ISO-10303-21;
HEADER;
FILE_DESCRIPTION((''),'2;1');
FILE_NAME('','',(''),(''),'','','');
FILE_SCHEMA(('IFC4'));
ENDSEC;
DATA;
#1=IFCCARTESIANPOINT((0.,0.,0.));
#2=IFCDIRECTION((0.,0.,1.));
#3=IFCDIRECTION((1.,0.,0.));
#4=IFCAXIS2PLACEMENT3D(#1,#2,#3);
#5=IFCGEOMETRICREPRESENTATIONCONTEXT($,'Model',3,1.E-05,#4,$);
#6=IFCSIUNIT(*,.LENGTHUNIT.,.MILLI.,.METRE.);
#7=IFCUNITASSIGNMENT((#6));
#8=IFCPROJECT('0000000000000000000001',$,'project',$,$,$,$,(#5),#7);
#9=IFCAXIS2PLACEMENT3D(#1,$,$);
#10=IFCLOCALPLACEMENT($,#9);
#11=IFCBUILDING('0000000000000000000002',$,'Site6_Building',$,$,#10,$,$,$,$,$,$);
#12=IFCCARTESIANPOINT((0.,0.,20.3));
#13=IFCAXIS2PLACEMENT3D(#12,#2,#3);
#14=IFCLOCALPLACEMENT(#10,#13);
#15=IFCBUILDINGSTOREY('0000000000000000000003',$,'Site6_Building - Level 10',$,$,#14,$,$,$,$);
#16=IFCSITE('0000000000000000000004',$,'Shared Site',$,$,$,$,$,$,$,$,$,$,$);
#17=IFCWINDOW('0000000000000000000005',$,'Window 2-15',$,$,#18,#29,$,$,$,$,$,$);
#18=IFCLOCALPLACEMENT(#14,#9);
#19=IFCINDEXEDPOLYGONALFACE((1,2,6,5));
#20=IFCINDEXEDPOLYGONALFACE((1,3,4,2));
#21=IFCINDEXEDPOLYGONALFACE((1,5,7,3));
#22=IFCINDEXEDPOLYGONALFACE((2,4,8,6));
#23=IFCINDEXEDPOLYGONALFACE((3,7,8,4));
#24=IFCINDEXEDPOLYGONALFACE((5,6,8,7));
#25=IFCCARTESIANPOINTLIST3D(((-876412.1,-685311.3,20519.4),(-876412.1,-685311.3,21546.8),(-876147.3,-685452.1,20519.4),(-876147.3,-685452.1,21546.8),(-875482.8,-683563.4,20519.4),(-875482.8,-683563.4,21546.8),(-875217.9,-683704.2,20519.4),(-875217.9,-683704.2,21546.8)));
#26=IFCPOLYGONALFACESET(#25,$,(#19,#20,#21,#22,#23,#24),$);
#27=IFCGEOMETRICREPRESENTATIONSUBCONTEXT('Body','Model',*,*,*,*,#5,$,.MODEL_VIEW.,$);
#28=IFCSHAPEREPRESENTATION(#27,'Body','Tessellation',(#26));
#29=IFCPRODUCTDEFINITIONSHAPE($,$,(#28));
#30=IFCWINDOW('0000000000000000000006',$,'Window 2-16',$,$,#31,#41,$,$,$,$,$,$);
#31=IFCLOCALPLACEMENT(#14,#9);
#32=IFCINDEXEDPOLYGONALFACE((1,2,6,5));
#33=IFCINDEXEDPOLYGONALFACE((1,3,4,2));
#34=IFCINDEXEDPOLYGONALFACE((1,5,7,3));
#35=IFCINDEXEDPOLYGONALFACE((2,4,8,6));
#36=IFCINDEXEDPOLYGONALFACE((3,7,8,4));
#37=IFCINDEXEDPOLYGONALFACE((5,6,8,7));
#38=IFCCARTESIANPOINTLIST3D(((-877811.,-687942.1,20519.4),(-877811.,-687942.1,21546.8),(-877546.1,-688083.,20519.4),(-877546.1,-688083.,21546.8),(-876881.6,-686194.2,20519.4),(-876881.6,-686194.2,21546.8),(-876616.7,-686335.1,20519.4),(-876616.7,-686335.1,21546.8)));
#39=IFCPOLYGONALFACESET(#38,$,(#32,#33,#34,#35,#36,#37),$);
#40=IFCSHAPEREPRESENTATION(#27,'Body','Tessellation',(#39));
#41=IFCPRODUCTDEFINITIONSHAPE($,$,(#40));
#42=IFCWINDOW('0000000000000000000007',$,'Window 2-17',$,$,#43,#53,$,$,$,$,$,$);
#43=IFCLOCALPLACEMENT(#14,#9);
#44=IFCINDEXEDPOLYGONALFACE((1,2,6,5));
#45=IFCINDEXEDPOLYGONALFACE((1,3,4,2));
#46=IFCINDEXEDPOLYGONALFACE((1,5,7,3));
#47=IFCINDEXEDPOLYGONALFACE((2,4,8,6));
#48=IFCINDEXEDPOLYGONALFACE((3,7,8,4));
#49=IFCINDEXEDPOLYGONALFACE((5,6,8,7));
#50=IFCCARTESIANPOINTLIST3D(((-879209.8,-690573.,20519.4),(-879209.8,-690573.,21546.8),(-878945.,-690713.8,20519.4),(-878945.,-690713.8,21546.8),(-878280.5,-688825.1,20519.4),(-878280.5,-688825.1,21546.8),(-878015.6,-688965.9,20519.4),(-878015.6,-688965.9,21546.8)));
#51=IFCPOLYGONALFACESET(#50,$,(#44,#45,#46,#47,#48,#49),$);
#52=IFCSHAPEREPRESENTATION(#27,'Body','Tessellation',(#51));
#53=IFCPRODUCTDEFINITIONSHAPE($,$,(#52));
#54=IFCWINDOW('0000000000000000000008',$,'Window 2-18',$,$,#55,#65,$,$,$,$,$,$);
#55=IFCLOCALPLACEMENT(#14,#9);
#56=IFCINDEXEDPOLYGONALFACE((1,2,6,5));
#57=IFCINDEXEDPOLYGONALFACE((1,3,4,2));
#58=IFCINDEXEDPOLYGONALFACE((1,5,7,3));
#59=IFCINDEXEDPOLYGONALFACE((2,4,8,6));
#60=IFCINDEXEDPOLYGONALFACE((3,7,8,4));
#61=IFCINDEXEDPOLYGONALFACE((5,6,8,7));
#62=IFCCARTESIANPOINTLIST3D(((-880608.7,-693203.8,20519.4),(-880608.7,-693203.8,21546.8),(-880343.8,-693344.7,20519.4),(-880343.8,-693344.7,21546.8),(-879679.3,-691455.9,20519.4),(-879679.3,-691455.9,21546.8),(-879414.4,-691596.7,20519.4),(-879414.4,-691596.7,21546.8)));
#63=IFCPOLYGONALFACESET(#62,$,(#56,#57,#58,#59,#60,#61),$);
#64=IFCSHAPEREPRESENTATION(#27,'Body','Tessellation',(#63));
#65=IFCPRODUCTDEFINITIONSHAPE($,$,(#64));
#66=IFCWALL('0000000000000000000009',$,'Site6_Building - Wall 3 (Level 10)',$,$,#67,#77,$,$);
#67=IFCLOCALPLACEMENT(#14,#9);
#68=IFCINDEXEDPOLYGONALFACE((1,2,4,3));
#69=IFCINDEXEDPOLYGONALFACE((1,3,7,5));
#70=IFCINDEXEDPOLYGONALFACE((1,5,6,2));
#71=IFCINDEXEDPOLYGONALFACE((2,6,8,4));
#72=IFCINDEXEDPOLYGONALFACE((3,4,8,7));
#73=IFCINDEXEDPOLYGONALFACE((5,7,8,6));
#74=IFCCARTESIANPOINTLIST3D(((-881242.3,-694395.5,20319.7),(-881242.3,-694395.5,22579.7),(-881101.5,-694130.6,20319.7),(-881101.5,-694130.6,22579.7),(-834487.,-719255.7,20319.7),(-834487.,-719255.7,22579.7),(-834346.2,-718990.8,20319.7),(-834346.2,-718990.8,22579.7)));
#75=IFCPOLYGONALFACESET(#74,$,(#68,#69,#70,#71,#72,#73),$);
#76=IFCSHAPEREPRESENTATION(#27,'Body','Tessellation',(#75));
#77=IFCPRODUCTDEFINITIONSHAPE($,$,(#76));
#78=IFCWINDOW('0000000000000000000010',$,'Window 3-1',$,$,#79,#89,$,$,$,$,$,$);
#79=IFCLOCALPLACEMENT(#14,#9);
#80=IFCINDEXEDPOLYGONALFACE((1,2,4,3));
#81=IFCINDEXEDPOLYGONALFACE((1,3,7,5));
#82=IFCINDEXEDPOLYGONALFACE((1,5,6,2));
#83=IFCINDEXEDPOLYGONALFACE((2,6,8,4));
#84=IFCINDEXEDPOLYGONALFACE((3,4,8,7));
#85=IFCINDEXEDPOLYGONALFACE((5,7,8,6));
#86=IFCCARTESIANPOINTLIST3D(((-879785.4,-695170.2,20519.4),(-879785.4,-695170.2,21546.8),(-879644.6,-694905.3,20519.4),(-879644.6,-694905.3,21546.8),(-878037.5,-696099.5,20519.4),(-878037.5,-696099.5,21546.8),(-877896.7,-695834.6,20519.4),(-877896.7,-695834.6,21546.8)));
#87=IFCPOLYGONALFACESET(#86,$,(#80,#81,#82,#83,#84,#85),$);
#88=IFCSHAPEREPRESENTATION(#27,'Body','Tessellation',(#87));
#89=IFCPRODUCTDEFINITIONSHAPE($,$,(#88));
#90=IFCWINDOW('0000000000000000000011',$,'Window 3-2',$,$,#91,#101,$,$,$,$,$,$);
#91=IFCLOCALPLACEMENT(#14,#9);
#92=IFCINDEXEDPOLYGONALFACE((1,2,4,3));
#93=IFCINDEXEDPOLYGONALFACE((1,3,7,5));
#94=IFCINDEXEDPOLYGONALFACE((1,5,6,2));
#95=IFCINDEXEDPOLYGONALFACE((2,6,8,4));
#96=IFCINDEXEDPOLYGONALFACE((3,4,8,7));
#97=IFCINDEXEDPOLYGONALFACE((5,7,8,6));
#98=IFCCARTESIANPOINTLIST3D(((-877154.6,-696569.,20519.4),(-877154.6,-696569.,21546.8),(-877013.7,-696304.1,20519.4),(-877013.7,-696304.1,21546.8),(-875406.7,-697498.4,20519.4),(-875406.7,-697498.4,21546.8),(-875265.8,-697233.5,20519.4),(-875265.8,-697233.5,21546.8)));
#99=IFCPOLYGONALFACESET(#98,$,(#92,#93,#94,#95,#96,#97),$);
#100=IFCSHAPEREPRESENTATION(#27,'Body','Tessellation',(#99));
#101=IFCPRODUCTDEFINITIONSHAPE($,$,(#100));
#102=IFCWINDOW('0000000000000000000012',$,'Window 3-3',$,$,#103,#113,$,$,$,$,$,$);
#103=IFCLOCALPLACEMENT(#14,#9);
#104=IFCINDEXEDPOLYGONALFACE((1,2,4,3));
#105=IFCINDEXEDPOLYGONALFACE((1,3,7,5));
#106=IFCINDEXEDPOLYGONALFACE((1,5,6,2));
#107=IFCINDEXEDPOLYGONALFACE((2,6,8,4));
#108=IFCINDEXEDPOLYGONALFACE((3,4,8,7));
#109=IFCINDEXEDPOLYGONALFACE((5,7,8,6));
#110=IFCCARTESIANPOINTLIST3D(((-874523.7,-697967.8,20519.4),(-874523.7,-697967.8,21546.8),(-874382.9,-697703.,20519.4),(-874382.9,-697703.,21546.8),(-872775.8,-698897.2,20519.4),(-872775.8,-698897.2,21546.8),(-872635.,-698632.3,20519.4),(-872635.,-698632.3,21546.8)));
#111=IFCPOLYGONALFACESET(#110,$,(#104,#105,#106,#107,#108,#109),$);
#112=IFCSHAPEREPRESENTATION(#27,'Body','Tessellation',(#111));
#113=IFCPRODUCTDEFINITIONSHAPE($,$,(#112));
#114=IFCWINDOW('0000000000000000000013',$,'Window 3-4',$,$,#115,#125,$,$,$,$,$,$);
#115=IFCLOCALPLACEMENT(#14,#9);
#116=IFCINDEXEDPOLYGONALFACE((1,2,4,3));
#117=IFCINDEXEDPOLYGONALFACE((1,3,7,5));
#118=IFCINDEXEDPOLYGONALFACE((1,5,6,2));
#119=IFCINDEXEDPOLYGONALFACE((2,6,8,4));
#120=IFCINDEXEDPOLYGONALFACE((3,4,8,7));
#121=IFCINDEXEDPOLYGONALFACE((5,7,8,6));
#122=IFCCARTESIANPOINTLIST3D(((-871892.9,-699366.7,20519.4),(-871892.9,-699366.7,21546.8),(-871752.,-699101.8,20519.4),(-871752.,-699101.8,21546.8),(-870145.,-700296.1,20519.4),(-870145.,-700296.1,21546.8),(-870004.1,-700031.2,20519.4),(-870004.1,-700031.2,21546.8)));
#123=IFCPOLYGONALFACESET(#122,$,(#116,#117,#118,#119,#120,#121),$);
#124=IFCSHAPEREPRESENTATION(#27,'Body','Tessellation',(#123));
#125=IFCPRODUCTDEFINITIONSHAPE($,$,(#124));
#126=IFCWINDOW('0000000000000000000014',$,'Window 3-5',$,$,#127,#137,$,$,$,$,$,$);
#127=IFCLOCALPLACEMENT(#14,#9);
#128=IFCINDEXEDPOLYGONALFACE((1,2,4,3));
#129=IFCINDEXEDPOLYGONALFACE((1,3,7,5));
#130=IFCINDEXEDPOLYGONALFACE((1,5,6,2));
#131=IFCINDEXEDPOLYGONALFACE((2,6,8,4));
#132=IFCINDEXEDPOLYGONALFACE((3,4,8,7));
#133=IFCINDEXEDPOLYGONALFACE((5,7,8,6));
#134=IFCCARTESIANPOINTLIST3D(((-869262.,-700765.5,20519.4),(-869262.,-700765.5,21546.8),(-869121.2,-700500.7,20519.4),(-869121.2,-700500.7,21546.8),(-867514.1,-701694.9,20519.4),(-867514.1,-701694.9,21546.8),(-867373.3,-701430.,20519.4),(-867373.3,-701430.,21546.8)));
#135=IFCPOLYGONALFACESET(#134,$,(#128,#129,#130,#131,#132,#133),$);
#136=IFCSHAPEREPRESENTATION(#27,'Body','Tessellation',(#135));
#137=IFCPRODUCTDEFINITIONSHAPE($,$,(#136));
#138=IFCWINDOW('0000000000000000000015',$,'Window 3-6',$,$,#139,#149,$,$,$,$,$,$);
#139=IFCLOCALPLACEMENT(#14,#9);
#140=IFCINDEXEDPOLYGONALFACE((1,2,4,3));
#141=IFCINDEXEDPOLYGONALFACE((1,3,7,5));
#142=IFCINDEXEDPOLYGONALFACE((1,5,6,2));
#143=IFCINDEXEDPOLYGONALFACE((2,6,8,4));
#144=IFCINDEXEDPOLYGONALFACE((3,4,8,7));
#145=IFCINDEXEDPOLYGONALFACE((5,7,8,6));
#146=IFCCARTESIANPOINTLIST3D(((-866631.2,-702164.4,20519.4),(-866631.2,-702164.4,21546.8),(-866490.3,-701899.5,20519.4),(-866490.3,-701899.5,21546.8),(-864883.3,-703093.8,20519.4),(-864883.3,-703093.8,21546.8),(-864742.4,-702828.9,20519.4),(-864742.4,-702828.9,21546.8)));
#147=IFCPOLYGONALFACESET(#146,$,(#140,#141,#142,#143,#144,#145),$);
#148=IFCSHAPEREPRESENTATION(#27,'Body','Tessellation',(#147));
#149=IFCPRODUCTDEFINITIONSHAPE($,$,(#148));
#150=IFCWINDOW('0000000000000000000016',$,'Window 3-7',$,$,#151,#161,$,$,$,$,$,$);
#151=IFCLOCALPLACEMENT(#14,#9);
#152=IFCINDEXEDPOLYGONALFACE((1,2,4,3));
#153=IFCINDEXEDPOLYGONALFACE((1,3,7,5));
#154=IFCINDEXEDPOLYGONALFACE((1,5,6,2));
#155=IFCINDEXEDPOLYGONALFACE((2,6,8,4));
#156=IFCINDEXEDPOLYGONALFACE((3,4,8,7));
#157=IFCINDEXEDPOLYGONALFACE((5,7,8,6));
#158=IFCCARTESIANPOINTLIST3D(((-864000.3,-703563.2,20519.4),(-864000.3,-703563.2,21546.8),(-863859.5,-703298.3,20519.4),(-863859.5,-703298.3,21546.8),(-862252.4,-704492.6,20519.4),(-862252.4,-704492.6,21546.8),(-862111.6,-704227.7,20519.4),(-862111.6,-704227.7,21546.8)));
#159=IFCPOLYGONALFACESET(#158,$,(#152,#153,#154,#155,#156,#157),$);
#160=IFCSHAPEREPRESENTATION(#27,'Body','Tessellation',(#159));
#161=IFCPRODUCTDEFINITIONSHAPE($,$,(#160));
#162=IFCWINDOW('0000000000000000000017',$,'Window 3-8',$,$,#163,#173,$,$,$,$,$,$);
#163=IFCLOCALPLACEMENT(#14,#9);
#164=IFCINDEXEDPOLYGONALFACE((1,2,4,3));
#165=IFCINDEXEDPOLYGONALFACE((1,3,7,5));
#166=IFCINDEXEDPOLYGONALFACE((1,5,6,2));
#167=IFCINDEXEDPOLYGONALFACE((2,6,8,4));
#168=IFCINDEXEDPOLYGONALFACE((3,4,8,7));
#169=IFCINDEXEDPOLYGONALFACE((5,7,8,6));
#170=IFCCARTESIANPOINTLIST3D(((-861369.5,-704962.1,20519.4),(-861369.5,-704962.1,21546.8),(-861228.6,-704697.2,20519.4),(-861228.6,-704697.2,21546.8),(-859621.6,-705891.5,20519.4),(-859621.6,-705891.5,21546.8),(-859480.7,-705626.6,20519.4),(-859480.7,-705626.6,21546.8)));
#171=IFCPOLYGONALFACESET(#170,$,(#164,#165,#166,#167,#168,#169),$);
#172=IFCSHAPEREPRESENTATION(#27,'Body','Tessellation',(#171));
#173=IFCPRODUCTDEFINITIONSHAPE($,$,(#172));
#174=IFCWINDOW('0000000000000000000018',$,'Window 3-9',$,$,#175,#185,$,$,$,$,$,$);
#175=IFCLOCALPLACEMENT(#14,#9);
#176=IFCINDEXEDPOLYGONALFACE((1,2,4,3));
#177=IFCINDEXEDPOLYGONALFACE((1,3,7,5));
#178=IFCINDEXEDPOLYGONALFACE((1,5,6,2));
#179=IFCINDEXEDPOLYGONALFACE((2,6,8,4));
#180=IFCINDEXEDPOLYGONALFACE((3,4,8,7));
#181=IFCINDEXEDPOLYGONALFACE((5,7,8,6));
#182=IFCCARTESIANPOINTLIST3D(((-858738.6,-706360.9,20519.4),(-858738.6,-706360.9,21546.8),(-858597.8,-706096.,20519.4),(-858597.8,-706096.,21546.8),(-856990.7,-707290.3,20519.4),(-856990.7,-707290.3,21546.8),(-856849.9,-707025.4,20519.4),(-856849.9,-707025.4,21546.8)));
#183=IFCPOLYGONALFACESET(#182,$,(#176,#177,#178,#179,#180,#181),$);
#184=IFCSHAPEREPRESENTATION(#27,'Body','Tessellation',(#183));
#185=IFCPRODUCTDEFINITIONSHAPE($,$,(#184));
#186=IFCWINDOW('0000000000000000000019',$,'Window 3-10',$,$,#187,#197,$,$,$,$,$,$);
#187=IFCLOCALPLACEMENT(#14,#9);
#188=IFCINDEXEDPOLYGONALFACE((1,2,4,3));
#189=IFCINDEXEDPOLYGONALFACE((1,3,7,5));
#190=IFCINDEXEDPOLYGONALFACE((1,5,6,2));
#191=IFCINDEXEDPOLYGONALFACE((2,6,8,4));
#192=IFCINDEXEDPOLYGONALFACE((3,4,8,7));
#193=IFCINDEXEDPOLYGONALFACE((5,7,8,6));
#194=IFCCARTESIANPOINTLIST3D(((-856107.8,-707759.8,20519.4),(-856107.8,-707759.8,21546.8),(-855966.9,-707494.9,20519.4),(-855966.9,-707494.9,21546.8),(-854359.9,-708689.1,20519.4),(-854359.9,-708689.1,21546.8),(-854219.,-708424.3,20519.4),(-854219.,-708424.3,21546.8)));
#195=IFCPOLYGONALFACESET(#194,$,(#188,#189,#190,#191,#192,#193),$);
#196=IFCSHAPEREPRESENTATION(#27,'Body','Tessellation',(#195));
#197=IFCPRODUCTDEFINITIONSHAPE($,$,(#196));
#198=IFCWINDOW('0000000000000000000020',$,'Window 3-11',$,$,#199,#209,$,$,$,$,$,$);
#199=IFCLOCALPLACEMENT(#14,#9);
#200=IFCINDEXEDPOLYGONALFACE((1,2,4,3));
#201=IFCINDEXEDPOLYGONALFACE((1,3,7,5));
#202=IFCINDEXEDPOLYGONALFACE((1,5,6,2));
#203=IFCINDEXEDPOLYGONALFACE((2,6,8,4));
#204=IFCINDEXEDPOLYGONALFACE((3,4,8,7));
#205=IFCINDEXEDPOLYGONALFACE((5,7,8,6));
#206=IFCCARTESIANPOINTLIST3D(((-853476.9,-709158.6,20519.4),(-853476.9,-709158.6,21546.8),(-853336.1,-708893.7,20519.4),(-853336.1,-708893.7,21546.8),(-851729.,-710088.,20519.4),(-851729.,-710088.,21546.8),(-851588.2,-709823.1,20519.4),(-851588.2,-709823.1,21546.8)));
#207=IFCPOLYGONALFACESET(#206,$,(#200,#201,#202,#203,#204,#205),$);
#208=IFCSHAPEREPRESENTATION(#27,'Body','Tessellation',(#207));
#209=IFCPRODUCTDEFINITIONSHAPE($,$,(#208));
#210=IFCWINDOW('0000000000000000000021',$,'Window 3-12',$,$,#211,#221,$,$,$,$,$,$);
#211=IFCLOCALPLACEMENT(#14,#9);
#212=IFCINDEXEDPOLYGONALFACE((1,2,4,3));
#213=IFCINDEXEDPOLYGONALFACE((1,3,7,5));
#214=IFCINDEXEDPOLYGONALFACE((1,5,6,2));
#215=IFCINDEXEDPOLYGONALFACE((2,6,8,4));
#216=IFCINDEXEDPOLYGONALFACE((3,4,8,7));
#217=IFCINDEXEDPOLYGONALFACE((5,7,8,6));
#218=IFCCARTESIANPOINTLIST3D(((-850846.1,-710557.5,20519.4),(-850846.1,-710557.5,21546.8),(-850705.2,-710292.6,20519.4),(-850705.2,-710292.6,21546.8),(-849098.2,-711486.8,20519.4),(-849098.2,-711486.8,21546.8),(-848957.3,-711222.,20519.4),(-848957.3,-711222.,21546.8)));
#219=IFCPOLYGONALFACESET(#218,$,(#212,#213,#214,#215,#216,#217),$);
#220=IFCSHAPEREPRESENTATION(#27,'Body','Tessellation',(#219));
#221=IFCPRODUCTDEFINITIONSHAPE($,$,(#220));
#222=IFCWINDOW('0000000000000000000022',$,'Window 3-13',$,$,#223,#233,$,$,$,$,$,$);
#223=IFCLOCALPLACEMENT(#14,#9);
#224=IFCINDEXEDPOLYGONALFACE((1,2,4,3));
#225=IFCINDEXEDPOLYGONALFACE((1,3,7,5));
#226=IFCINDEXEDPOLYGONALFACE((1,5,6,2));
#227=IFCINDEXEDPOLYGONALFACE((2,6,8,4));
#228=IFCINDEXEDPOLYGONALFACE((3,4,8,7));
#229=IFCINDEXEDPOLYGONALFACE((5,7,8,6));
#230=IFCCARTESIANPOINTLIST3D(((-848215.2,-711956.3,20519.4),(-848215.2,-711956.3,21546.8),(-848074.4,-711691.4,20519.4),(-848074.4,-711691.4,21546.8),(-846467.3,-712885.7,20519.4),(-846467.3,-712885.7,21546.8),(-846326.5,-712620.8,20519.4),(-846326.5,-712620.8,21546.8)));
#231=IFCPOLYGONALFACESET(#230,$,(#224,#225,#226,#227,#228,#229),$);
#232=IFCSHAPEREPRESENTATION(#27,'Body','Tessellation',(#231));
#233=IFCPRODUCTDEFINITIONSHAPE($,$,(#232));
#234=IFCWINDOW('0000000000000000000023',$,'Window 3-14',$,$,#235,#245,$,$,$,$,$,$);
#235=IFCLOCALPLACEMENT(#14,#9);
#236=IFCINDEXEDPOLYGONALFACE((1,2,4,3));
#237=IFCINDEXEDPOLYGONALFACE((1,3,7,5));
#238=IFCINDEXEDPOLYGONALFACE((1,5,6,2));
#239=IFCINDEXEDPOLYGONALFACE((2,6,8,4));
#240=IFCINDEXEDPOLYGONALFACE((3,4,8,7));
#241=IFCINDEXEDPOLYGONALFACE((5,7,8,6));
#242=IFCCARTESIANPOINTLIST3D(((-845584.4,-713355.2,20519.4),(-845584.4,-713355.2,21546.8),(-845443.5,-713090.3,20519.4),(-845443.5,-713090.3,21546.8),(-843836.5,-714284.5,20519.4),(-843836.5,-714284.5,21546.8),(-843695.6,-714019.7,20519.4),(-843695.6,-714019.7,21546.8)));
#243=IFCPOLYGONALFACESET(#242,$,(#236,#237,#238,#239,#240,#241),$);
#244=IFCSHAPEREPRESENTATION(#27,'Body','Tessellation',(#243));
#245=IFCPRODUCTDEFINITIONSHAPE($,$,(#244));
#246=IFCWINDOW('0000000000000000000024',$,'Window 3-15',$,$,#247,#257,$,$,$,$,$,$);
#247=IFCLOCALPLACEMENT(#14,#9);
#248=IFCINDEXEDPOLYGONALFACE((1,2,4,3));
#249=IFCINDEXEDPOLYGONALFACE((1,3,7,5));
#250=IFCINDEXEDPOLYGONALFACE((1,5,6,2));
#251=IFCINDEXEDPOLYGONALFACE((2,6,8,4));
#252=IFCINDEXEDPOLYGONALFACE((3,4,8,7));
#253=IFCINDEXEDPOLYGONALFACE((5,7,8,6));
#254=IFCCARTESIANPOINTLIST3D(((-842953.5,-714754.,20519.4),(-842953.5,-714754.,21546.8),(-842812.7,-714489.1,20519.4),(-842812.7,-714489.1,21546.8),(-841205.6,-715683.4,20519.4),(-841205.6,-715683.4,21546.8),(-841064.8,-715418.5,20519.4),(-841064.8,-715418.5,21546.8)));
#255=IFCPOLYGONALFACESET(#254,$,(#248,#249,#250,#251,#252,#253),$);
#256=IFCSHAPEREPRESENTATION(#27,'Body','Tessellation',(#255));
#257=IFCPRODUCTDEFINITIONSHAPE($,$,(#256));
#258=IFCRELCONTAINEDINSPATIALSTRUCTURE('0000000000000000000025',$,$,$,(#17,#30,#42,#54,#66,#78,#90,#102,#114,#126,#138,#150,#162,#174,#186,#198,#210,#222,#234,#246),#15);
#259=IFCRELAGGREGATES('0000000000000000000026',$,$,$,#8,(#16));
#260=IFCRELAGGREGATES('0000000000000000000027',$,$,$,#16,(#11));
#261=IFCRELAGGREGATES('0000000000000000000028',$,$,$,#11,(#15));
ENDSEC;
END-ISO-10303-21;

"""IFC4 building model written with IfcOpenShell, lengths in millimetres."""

from ifc_helpers import new_model, si_unit, frame, origin, origin_with_axes, place, context, subcontext, project, spatial, indexed_curve, outline, extrude, element, save


model = new_model("IFC4")

# Units and contexts
model_context = context("Model", 3, precision=1e-05, world=origin_with_axes())
body_context = subcontext(model_context, "Body", "Model", "MODEL_VIEW")
ifc_project = project(units=[si_unit("LENGTHUNIT", "METRE", prefix="MILLI")], contexts=[model_context])

# Site, building, storey
site = spatial("IfcSite", under=ifc_project, Name="Shared Site")
building_placement = place(None, origin())
building = spatial("IfcBuilding", under=site, at=building_placement, Name="Site6_Building")
storey_placement = place(building_placement, frame((0.0, 0.0, 20.3), z_axis=(0.0, 0.0, 1.0), x_axis=(1.0, 0.0, 0.0)))
storey = spatial("IfcBuildingStorey", under=building, at=storey_placement, Name="Site6_Building - Level 10")

# Windows
for number, where, z_axis, x_axis, name in (
    (1, (-875482.8, -683563.4, 20519.4), (0.0, 0.0, 1.0), (-0.469472, -0.882948, 0.0), "Window 2-15"),
    (2, (-876881.6, -686194.2, 20519.4), (0.0, 0.0, 1.0), (-0.469472, -0.882948, 0.0), "Window 2-16"),
    (3, (-878280.5, -688825.1, 20519.4), (0.0, 0.0, 1.0), (-0.469472, -0.882948, 0.0), "Window 2-17"),
    (4, (-879679.3, -691455.9, 20519.4), (0.0, 0.0, 1.0), (-0.469472, -0.882948, 0.0), "Window 2-18"),
):
    element("IfcWindow", number, at=place(storey_placement, frame(where, z_axis=z_axis, x_axis=x_axis)), inside=storey, Name=name, context=body_context, shape_type="SweptSolid", body=[
        extrude(outline(indexed_curve([(0.0, 0.0), (0.0, 300.0), (1979.6, 300.0), (1979.6, 0.0), (0.0, 0.0)], self_intersect=False)), origin_with_axes(), (0.0, 0.0, 1.0), 1027.5),
    ])

# Wall
wall_1_placement = place(storey_placement, frame((-881242.3, -694395.5, 20319.7), z_axis=(0.0, 0.0, 1.0), x_axis=(0.882948, -0.469472, 0.0)))
element("IfcWall", 5, at=wall_1_placement, inside=storey, Name="Site6_Building - Wall 3 (Level 10)", context=body_context, shape_type="SweptSolid", body=[
    extrude(outline(indexed_curve([(0.0, 0.0), (0.0, 300.0), (52953.6, 300.0), (52953.6, 0.0), (0.0, 0.0)], self_intersect=False)), origin_with_axes(), (0.0, 0.0, 1.0), 2260.0),
])

# Windows
for number, where, z_axis, x_axis, name in (
    (6, (-879785.4, -695170.2, 20519.4), (0.0, 0.0, 1.0), (0.882948, -0.469472, 0.0), "Window 3-1"),
    (7, (-877154.6, -696569.0, 20519.4), (0.0, 0.0, 1.0), (0.882948, -0.469472, 0.0), "Window 3-2"),
    (8, (-874523.7, -697967.8, 20519.4), (0.0, 0.0, 1.0), (0.882948, -0.469472, 0.0), "Window 3-3"),
    (9, (-871892.9, -699366.7, 20519.4), (0.0, 0.0, 1.0), (0.882948, -0.469472, 0.0), "Window 3-4"),
    (10, (-869262.0, -700765.5, 20519.4), (0.0, 0.0, 1.0), (0.882948, -0.469472, 0.0), "Window 3-5"),
    (11, (-866631.2, -702164.4, 20519.4), (0.0, 0.0, 1.0), (0.882948, -0.469472, 0.0), "Window 3-6"),
    (12, (-864000.3, -703563.2, 20519.4), (0.0, 0.0, 1.0), (0.882948, -0.469472, 0.0), "Window 3-7"),
    (13, (-861369.5, -704962.1, 20519.4), (0.0, 0.0, 1.0), (0.882948, -0.469472, 0.0), "Window 3-8"),
    (14, (-858738.6, -706360.9, 20519.4), (0.0, 0.0, 1.0), (0.882948, -0.469472, 0.0), "Window 3-9"),
    (15, (-856107.8, -707759.8, 20519.4), (0.0, 0.0, 1.0), (0.882948, -0.469472, 0.0), "Window 3-10"),
    (16, (-853476.9, -709158.6, 20519.4), (0.0, 0.0, 1.0), (0.882948, -0.469472, 0.0), "Window 3-11"),
    (17, (-850846.1, -710557.5, 20519.4), (0.0, 0.0, 1.0), (0.882948, -0.469472, 0.0), "Window 3-12"),
    (18, (-848215.2, -711956.3, 20519.4), (0.0, 0.0, 1.0), (0.882948, -0.469472, 0.0), "Window 3-13"),
    (19, (-845584.4, -713355.2, 20519.4), (0.0, 0.0, 1.0), (0.882948, -0.469472, 0.0), "Window 3-14"),
    (20, (-842953.5, -714754.0, 20519.4), (0.0, 0.0, 1.0), (0.882948, -0.469472, 0.0), "Window 3-15"),
):
    element("IfcWindow", number, at=place(storey_placement, frame(where, z_axis=z_axis, x_axis=x_axis)), inside=storey, Name=name, context=body_context, shape_type="SweptSolid", body=[
        extrude(outline(indexed_curve([(0.0, 0.0), (0.0, 300.0), (1979.6, 300.0), (1979.6, 0.0), (0.0, 0.0)], self_intersect=False)), origin_with_axes(), (0.0, 0.0, 1.0), 1027.5),
    ])

save(model, "model.ifc")
